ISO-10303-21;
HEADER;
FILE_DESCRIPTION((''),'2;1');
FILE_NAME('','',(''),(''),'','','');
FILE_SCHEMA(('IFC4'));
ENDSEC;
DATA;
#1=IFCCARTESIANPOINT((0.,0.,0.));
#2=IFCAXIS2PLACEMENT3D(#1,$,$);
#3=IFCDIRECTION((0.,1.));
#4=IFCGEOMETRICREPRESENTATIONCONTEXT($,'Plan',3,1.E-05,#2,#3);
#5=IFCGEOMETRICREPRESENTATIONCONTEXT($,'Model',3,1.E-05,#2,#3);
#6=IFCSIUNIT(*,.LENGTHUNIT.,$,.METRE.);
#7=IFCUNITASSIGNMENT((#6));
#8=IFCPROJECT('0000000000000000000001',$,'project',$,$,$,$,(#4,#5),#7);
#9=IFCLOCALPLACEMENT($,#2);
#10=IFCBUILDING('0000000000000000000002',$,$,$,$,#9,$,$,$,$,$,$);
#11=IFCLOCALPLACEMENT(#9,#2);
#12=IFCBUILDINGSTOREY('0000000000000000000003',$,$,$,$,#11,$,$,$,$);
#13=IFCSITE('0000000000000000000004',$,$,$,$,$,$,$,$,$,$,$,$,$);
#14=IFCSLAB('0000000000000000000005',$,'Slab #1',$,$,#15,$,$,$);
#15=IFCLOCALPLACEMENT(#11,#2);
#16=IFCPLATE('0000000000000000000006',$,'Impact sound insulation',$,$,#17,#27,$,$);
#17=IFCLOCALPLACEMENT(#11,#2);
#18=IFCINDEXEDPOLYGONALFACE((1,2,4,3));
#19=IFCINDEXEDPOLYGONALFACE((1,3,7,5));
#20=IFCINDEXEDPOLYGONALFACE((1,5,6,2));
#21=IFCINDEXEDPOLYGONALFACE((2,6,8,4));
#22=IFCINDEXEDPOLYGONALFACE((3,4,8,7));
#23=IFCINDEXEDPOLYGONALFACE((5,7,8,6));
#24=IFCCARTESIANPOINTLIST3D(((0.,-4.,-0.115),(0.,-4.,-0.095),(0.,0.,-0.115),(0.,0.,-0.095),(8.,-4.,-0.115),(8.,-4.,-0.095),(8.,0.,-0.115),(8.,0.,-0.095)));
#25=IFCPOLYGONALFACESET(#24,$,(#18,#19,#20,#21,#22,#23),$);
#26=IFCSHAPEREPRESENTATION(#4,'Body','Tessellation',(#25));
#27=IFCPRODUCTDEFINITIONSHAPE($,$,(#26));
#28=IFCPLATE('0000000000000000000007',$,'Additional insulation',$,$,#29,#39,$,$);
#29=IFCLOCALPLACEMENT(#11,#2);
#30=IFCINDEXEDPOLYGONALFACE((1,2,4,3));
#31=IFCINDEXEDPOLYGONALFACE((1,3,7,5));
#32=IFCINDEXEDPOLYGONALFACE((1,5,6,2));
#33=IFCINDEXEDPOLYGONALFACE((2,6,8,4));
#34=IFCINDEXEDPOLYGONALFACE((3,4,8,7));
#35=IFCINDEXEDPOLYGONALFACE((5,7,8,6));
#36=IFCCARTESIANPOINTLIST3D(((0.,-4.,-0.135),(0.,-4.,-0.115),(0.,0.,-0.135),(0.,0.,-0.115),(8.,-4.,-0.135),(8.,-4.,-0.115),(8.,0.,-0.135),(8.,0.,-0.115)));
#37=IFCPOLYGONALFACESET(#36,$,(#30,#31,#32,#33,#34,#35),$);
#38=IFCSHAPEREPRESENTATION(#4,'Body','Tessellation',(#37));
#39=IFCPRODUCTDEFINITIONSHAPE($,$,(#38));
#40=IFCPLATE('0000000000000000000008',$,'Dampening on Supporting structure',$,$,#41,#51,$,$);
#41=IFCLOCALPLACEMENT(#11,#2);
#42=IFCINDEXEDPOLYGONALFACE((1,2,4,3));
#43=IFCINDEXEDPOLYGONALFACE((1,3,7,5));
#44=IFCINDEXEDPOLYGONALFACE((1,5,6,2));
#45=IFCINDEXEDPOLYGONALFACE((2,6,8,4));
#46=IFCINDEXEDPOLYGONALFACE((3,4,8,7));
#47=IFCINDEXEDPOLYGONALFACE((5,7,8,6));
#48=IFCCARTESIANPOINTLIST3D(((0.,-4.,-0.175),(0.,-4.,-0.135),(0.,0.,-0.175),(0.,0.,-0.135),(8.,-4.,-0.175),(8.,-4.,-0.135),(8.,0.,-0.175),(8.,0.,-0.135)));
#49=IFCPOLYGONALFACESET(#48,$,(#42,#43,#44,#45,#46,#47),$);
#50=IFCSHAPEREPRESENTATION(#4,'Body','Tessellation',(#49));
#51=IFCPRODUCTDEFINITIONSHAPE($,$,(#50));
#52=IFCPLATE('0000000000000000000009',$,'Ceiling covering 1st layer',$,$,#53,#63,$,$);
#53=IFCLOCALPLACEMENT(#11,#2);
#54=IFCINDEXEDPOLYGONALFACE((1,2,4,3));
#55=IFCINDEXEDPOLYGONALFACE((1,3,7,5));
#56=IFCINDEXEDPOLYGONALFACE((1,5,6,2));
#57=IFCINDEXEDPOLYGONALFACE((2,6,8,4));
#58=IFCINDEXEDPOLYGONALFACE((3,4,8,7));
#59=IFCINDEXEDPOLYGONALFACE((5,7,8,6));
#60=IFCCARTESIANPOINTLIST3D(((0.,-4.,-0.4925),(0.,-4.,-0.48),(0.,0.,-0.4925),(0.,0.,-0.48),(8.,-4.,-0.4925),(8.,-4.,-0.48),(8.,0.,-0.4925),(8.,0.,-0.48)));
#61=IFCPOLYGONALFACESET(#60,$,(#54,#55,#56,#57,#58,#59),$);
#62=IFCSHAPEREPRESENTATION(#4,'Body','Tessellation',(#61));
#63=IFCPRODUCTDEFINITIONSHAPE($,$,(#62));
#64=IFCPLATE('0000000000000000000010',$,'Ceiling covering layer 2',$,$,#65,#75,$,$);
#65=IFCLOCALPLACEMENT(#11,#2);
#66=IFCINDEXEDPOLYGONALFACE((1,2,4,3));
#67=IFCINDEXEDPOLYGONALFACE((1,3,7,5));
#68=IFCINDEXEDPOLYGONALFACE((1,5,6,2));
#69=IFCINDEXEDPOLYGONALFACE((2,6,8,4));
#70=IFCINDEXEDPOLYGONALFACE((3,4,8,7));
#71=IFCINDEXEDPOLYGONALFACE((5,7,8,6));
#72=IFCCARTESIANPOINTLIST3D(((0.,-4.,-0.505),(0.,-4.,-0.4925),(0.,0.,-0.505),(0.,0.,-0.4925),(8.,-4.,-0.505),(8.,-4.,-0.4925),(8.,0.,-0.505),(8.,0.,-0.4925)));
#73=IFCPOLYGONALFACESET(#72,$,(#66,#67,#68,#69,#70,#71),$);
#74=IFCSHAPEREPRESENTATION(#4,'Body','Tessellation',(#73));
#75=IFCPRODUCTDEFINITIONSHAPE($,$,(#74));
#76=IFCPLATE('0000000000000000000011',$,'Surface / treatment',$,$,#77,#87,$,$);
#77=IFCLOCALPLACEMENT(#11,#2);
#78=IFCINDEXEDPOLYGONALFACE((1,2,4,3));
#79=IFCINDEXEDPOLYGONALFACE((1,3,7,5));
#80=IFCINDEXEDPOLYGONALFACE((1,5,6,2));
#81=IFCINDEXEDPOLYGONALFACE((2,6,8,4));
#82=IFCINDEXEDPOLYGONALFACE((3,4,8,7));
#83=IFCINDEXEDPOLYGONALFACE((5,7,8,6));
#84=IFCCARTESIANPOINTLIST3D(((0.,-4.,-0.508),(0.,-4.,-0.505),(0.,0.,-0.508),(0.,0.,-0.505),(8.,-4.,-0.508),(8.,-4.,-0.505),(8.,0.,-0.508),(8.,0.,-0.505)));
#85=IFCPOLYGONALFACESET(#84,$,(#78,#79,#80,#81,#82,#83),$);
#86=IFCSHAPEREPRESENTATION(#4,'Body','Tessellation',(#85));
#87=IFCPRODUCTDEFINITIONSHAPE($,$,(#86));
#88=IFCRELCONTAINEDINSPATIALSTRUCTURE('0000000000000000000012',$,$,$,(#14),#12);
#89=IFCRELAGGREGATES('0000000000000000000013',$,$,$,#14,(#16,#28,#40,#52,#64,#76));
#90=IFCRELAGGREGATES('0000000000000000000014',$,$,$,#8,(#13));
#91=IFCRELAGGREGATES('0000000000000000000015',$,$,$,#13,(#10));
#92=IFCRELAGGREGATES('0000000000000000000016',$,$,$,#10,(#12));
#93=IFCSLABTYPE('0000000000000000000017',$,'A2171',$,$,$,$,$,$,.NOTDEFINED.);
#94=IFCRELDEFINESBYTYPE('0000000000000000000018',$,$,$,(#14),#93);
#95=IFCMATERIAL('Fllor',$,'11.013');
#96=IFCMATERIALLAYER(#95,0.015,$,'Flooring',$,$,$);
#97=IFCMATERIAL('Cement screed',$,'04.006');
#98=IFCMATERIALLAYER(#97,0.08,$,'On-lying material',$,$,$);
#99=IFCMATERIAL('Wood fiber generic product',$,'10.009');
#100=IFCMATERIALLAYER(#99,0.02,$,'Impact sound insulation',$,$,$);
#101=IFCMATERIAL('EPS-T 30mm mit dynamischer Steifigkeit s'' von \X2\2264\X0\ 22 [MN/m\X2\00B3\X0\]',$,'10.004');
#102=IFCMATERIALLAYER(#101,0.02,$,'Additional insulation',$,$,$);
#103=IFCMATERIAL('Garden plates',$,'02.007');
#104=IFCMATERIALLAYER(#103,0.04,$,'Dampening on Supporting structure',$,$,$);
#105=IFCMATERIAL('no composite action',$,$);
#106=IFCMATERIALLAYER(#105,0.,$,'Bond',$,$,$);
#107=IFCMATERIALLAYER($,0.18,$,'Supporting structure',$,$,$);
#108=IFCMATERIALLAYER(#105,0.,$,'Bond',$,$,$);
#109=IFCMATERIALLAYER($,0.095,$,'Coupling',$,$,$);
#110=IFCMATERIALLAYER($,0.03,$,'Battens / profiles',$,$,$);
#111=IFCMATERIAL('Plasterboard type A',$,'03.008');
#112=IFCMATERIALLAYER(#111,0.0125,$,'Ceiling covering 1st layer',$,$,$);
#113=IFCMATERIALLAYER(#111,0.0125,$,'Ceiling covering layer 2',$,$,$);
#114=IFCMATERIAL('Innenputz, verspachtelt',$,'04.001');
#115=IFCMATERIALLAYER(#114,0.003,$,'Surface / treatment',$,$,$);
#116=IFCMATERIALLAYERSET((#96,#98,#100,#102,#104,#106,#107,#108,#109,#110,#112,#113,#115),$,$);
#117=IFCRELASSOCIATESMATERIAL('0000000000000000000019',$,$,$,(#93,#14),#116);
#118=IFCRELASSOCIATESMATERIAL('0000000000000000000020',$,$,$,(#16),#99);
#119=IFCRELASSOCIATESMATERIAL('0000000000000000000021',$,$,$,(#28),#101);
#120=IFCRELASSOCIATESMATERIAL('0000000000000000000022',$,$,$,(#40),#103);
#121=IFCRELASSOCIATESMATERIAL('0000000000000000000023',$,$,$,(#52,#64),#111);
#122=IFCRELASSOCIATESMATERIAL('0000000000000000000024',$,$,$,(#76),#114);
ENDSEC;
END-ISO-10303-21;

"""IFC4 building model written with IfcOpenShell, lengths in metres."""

from ifc_helpers import new_model, si_unit, direction, frame, frame_2d, origin, place, context, project, spatial, rectangle, extrude, material, layer, layer_set, type_object, element, aggregate, save


model = new_model("IFC4")

# Units and contexts
plan_context = context("Plan", 3, precision=1e-05, world=origin(), true_north=direction((0.0, 1.0)))
model_context = context("Model", 3, precision=1e-05, world=origin(), true_north=direction((0.0, 1.0)))
ifc_project = project(units=[si_unit("LENGTHUNIT", "METRE")], contexts=[plan_context, model_context])

# Site, building, storey
site = spatial("IfcSite", under=ifc_project)
building_placement = place(None, origin())
building = spatial("IfcBuilding", under=site, at=building_placement)
storey_placement = place(building_placement, origin())
storey = spatial("IfcBuildingStorey", under=building, at=storey_placement)

# Slab, plates
ifc_material_1 = material(Name="Fllor", Category="11.013")
ifc_layer_1 = layer(ifc_material_1, 0.015, Name="Flooring")
ifc_material_2 = material(Name="Cement screed", Category="04.006")
ifc_layer_2 = layer(ifc_material_2, 0.08, Name="On-lying material")
ifc_material_3 = material(Name="Wood fiber generic product", Category="10.009")
ifc_layer_3 = layer(ifc_material_3, 0.02, Name="Impact sound insulation")
ifc_material_4 = material(Name="EPS-T 30mm mit dynamischer Steifigkeit s' von ≤ 22 [MN/m³]", Category="10.004")
ifc_layer_4 = layer(ifc_material_4, 0.02, Name="Additional insulation")
ifc_material_5 = material(Name="Garden plates", Category="02.007")
ifc_layer_5 = layer(ifc_material_5, 0.04, Name="Dampening on Supporting structure")
ifc_material_6 = material(Name="no composite action")
ifc_layer_6 = layer(ifc_material_6, 0.0, Name="Bond")
ifc_layer_7 = layer(None, 0.18, Name="Supporting structure")
ifc_layer_8 = layer(ifc_material_6, 0.0, Name="Bond")
ifc_layer_9 = layer(None, 0.095, Name="Coupling")
ifc_layer_10 = layer(None, 0.03, Name="Battens / profiles")
ifc_material_7 = material(Name="Plasterboard type A", Category="03.008")
ifc_layer_11 = layer(ifc_material_7, 0.0125, Name="Ceiling covering 1st layer")
ifc_layer_12 = layer(ifc_material_7, 0.0125, Name="Ceiling covering layer 2")
ifc_material_8 = material(Name="Innenputz, verspachtelt", Category="04.001")
ifc_layer_13 = layer(ifc_material_8, 0.003, Name="Surface / treatment")
ifc_layer_set = layer_set([ifc_layer_1, ifc_layer_2, ifc_layer_3, ifc_layer_4, ifc_layer_5, ifc_layer_6, ifc_layer_7, ifc_layer_8, ifc_layer_9, ifc_layer_10, ifc_layer_11, ifc_layer_12, ifc_layer_13])
slab_type = type_object("IfcSlabType", Name="A2171", PredefinedType="NOTDEFINED", material=ifc_layer_set)
slab_placement = place(None, frame((0.0, 0.0, 0.0), z_axis=(0.0, 0.0, -1.0), x_axis=(1.0, 0.0, 0.0)))
slab = element("IfcSlab", 1, at=slab_placement, inside=storey, type_object=slab_type, material=ifc_layer_set, Name="Slab #1")
plate_1_placement = place(slab_placement, origin())
plate_1 = element("IfcPlate", 2, at=plate_1_placement, material=ifc_material_3, Name="Impact sound insulation", context=plan_context, shape_type="SweptSolid", body=[
    extrude(rectangle(XDim=8.0, YDim=4.0, at=frame_2d((4.0, 2.0), x_axis=(1.0, 0.0))), frame((0.0, 0.0, 0.095), z_axis=(0.0, 0.0, 1.0), x_axis=(1.0, 0.0, 0.0)), (0.0, 0.0, 1.0), 0.02),
])
plate_2_placement = place(slab_placement, origin())
plate_2 = element("IfcPlate", 3, at=plate_2_placement, material=ifc_material_4, Name="Additional insulation", context=plan_context, shape_type="SweptSolid", body=[
    extrude(rectangle(XDim=8.0, YDim=4.0, at=frame_2d((4.0, 2.0), x_axis=(1.0, 0.0))), frame((0.0, 0.0, 0.115), z_axis=(0.0, 0.0, 1.0), x_axis=(1.0, 0.0, 0.0)), (0.0, 0.0, 1.0), 0.02),
])
plate_3_placement = place(slab_placement, origin())
plate_3 = element("IfcPlate", 4, at=plate_3_placement, material=ifc_material_5, Name="Dampening on Supporting structure", context=plan_context, shape_type="SweptSolid", body=[
    extrude(rectangle(XDim=8.0, YDim=4.0, at=frame_2d((4.0, 2.0), x_axis=(1.0, 0.0))), frame((0.0, 0.0, 0.135), z_axis=(0.0, 0.0, 1.0), x_axis=(1.0, 0.0, 0.0)), (0.0, 0.0, 1.0), 0.04),
])
plate_4_placement = place(slab_placement, origin())
plate_4 = element("IfcPlate", 5, at=plate_4_placement, material=ifc_material_7, Name="Ceiling covering 1st layer", context=plan_context, shape_type="SweptSolid", body=[
    extrude(rectangle(XDim=8.0, YDim=4.0, at=frame_2d((4.0, 2.0), x_axis=(1.0, 0.0))), frame((0.0, 0.0, 0.48), z_axis=(0.0, 0.0, 1.0), x_axis=(1.0, 0.0, 0.0)), (0.0, 0.0, 1.0), 0.0125),
])
plate_5_placement = place(slab_placement, origin())
plate_5 = element("IfcPlate", 6, at=plate_5_placement, material=ifc_material_7, Name="Ceiling covering layer 2", context=plan_context, shape_type="SweptSolid", body=[
    extrude(rectangle(XDim=8.0, YDim=4.0, at=frame_2d((4.0, 2.0), x_axis=(1.0, 0.0))), frame((0.0, 0.0, 0.4925), z_axis=(0.0, 0.0, 1.0), x_axis=(1.0, 0.0, 0.0)), (0.0, 0.0, 1.0), 0.0125),
])
plate_6_placement = place(slab_placement, origin())
plate_6 = element("IfcPlate", 7, at=plate_6_placement, material=ifc_material_8, Name="Surface / treatment", context=plan_context, shape_type="SweptSolid", body=[
    extrude(rectangle(XDim=8.0, YDim=4.0, at=frame_2d((4.0, 2.0), x_axis=(1.0, 0.0))), frame((0.0, 0.0, 0.505), z_axis=(0.0, 0.0, 1.0), x_axis=(1.0, 0.0, 0.0)), (0.0, 0.0, 1.0), 0.003),
])
aggregate(slab, [plate_1, plate_2, plate_3, plate_4, plate_5, plate_6])

save(model, "model.ifc")
